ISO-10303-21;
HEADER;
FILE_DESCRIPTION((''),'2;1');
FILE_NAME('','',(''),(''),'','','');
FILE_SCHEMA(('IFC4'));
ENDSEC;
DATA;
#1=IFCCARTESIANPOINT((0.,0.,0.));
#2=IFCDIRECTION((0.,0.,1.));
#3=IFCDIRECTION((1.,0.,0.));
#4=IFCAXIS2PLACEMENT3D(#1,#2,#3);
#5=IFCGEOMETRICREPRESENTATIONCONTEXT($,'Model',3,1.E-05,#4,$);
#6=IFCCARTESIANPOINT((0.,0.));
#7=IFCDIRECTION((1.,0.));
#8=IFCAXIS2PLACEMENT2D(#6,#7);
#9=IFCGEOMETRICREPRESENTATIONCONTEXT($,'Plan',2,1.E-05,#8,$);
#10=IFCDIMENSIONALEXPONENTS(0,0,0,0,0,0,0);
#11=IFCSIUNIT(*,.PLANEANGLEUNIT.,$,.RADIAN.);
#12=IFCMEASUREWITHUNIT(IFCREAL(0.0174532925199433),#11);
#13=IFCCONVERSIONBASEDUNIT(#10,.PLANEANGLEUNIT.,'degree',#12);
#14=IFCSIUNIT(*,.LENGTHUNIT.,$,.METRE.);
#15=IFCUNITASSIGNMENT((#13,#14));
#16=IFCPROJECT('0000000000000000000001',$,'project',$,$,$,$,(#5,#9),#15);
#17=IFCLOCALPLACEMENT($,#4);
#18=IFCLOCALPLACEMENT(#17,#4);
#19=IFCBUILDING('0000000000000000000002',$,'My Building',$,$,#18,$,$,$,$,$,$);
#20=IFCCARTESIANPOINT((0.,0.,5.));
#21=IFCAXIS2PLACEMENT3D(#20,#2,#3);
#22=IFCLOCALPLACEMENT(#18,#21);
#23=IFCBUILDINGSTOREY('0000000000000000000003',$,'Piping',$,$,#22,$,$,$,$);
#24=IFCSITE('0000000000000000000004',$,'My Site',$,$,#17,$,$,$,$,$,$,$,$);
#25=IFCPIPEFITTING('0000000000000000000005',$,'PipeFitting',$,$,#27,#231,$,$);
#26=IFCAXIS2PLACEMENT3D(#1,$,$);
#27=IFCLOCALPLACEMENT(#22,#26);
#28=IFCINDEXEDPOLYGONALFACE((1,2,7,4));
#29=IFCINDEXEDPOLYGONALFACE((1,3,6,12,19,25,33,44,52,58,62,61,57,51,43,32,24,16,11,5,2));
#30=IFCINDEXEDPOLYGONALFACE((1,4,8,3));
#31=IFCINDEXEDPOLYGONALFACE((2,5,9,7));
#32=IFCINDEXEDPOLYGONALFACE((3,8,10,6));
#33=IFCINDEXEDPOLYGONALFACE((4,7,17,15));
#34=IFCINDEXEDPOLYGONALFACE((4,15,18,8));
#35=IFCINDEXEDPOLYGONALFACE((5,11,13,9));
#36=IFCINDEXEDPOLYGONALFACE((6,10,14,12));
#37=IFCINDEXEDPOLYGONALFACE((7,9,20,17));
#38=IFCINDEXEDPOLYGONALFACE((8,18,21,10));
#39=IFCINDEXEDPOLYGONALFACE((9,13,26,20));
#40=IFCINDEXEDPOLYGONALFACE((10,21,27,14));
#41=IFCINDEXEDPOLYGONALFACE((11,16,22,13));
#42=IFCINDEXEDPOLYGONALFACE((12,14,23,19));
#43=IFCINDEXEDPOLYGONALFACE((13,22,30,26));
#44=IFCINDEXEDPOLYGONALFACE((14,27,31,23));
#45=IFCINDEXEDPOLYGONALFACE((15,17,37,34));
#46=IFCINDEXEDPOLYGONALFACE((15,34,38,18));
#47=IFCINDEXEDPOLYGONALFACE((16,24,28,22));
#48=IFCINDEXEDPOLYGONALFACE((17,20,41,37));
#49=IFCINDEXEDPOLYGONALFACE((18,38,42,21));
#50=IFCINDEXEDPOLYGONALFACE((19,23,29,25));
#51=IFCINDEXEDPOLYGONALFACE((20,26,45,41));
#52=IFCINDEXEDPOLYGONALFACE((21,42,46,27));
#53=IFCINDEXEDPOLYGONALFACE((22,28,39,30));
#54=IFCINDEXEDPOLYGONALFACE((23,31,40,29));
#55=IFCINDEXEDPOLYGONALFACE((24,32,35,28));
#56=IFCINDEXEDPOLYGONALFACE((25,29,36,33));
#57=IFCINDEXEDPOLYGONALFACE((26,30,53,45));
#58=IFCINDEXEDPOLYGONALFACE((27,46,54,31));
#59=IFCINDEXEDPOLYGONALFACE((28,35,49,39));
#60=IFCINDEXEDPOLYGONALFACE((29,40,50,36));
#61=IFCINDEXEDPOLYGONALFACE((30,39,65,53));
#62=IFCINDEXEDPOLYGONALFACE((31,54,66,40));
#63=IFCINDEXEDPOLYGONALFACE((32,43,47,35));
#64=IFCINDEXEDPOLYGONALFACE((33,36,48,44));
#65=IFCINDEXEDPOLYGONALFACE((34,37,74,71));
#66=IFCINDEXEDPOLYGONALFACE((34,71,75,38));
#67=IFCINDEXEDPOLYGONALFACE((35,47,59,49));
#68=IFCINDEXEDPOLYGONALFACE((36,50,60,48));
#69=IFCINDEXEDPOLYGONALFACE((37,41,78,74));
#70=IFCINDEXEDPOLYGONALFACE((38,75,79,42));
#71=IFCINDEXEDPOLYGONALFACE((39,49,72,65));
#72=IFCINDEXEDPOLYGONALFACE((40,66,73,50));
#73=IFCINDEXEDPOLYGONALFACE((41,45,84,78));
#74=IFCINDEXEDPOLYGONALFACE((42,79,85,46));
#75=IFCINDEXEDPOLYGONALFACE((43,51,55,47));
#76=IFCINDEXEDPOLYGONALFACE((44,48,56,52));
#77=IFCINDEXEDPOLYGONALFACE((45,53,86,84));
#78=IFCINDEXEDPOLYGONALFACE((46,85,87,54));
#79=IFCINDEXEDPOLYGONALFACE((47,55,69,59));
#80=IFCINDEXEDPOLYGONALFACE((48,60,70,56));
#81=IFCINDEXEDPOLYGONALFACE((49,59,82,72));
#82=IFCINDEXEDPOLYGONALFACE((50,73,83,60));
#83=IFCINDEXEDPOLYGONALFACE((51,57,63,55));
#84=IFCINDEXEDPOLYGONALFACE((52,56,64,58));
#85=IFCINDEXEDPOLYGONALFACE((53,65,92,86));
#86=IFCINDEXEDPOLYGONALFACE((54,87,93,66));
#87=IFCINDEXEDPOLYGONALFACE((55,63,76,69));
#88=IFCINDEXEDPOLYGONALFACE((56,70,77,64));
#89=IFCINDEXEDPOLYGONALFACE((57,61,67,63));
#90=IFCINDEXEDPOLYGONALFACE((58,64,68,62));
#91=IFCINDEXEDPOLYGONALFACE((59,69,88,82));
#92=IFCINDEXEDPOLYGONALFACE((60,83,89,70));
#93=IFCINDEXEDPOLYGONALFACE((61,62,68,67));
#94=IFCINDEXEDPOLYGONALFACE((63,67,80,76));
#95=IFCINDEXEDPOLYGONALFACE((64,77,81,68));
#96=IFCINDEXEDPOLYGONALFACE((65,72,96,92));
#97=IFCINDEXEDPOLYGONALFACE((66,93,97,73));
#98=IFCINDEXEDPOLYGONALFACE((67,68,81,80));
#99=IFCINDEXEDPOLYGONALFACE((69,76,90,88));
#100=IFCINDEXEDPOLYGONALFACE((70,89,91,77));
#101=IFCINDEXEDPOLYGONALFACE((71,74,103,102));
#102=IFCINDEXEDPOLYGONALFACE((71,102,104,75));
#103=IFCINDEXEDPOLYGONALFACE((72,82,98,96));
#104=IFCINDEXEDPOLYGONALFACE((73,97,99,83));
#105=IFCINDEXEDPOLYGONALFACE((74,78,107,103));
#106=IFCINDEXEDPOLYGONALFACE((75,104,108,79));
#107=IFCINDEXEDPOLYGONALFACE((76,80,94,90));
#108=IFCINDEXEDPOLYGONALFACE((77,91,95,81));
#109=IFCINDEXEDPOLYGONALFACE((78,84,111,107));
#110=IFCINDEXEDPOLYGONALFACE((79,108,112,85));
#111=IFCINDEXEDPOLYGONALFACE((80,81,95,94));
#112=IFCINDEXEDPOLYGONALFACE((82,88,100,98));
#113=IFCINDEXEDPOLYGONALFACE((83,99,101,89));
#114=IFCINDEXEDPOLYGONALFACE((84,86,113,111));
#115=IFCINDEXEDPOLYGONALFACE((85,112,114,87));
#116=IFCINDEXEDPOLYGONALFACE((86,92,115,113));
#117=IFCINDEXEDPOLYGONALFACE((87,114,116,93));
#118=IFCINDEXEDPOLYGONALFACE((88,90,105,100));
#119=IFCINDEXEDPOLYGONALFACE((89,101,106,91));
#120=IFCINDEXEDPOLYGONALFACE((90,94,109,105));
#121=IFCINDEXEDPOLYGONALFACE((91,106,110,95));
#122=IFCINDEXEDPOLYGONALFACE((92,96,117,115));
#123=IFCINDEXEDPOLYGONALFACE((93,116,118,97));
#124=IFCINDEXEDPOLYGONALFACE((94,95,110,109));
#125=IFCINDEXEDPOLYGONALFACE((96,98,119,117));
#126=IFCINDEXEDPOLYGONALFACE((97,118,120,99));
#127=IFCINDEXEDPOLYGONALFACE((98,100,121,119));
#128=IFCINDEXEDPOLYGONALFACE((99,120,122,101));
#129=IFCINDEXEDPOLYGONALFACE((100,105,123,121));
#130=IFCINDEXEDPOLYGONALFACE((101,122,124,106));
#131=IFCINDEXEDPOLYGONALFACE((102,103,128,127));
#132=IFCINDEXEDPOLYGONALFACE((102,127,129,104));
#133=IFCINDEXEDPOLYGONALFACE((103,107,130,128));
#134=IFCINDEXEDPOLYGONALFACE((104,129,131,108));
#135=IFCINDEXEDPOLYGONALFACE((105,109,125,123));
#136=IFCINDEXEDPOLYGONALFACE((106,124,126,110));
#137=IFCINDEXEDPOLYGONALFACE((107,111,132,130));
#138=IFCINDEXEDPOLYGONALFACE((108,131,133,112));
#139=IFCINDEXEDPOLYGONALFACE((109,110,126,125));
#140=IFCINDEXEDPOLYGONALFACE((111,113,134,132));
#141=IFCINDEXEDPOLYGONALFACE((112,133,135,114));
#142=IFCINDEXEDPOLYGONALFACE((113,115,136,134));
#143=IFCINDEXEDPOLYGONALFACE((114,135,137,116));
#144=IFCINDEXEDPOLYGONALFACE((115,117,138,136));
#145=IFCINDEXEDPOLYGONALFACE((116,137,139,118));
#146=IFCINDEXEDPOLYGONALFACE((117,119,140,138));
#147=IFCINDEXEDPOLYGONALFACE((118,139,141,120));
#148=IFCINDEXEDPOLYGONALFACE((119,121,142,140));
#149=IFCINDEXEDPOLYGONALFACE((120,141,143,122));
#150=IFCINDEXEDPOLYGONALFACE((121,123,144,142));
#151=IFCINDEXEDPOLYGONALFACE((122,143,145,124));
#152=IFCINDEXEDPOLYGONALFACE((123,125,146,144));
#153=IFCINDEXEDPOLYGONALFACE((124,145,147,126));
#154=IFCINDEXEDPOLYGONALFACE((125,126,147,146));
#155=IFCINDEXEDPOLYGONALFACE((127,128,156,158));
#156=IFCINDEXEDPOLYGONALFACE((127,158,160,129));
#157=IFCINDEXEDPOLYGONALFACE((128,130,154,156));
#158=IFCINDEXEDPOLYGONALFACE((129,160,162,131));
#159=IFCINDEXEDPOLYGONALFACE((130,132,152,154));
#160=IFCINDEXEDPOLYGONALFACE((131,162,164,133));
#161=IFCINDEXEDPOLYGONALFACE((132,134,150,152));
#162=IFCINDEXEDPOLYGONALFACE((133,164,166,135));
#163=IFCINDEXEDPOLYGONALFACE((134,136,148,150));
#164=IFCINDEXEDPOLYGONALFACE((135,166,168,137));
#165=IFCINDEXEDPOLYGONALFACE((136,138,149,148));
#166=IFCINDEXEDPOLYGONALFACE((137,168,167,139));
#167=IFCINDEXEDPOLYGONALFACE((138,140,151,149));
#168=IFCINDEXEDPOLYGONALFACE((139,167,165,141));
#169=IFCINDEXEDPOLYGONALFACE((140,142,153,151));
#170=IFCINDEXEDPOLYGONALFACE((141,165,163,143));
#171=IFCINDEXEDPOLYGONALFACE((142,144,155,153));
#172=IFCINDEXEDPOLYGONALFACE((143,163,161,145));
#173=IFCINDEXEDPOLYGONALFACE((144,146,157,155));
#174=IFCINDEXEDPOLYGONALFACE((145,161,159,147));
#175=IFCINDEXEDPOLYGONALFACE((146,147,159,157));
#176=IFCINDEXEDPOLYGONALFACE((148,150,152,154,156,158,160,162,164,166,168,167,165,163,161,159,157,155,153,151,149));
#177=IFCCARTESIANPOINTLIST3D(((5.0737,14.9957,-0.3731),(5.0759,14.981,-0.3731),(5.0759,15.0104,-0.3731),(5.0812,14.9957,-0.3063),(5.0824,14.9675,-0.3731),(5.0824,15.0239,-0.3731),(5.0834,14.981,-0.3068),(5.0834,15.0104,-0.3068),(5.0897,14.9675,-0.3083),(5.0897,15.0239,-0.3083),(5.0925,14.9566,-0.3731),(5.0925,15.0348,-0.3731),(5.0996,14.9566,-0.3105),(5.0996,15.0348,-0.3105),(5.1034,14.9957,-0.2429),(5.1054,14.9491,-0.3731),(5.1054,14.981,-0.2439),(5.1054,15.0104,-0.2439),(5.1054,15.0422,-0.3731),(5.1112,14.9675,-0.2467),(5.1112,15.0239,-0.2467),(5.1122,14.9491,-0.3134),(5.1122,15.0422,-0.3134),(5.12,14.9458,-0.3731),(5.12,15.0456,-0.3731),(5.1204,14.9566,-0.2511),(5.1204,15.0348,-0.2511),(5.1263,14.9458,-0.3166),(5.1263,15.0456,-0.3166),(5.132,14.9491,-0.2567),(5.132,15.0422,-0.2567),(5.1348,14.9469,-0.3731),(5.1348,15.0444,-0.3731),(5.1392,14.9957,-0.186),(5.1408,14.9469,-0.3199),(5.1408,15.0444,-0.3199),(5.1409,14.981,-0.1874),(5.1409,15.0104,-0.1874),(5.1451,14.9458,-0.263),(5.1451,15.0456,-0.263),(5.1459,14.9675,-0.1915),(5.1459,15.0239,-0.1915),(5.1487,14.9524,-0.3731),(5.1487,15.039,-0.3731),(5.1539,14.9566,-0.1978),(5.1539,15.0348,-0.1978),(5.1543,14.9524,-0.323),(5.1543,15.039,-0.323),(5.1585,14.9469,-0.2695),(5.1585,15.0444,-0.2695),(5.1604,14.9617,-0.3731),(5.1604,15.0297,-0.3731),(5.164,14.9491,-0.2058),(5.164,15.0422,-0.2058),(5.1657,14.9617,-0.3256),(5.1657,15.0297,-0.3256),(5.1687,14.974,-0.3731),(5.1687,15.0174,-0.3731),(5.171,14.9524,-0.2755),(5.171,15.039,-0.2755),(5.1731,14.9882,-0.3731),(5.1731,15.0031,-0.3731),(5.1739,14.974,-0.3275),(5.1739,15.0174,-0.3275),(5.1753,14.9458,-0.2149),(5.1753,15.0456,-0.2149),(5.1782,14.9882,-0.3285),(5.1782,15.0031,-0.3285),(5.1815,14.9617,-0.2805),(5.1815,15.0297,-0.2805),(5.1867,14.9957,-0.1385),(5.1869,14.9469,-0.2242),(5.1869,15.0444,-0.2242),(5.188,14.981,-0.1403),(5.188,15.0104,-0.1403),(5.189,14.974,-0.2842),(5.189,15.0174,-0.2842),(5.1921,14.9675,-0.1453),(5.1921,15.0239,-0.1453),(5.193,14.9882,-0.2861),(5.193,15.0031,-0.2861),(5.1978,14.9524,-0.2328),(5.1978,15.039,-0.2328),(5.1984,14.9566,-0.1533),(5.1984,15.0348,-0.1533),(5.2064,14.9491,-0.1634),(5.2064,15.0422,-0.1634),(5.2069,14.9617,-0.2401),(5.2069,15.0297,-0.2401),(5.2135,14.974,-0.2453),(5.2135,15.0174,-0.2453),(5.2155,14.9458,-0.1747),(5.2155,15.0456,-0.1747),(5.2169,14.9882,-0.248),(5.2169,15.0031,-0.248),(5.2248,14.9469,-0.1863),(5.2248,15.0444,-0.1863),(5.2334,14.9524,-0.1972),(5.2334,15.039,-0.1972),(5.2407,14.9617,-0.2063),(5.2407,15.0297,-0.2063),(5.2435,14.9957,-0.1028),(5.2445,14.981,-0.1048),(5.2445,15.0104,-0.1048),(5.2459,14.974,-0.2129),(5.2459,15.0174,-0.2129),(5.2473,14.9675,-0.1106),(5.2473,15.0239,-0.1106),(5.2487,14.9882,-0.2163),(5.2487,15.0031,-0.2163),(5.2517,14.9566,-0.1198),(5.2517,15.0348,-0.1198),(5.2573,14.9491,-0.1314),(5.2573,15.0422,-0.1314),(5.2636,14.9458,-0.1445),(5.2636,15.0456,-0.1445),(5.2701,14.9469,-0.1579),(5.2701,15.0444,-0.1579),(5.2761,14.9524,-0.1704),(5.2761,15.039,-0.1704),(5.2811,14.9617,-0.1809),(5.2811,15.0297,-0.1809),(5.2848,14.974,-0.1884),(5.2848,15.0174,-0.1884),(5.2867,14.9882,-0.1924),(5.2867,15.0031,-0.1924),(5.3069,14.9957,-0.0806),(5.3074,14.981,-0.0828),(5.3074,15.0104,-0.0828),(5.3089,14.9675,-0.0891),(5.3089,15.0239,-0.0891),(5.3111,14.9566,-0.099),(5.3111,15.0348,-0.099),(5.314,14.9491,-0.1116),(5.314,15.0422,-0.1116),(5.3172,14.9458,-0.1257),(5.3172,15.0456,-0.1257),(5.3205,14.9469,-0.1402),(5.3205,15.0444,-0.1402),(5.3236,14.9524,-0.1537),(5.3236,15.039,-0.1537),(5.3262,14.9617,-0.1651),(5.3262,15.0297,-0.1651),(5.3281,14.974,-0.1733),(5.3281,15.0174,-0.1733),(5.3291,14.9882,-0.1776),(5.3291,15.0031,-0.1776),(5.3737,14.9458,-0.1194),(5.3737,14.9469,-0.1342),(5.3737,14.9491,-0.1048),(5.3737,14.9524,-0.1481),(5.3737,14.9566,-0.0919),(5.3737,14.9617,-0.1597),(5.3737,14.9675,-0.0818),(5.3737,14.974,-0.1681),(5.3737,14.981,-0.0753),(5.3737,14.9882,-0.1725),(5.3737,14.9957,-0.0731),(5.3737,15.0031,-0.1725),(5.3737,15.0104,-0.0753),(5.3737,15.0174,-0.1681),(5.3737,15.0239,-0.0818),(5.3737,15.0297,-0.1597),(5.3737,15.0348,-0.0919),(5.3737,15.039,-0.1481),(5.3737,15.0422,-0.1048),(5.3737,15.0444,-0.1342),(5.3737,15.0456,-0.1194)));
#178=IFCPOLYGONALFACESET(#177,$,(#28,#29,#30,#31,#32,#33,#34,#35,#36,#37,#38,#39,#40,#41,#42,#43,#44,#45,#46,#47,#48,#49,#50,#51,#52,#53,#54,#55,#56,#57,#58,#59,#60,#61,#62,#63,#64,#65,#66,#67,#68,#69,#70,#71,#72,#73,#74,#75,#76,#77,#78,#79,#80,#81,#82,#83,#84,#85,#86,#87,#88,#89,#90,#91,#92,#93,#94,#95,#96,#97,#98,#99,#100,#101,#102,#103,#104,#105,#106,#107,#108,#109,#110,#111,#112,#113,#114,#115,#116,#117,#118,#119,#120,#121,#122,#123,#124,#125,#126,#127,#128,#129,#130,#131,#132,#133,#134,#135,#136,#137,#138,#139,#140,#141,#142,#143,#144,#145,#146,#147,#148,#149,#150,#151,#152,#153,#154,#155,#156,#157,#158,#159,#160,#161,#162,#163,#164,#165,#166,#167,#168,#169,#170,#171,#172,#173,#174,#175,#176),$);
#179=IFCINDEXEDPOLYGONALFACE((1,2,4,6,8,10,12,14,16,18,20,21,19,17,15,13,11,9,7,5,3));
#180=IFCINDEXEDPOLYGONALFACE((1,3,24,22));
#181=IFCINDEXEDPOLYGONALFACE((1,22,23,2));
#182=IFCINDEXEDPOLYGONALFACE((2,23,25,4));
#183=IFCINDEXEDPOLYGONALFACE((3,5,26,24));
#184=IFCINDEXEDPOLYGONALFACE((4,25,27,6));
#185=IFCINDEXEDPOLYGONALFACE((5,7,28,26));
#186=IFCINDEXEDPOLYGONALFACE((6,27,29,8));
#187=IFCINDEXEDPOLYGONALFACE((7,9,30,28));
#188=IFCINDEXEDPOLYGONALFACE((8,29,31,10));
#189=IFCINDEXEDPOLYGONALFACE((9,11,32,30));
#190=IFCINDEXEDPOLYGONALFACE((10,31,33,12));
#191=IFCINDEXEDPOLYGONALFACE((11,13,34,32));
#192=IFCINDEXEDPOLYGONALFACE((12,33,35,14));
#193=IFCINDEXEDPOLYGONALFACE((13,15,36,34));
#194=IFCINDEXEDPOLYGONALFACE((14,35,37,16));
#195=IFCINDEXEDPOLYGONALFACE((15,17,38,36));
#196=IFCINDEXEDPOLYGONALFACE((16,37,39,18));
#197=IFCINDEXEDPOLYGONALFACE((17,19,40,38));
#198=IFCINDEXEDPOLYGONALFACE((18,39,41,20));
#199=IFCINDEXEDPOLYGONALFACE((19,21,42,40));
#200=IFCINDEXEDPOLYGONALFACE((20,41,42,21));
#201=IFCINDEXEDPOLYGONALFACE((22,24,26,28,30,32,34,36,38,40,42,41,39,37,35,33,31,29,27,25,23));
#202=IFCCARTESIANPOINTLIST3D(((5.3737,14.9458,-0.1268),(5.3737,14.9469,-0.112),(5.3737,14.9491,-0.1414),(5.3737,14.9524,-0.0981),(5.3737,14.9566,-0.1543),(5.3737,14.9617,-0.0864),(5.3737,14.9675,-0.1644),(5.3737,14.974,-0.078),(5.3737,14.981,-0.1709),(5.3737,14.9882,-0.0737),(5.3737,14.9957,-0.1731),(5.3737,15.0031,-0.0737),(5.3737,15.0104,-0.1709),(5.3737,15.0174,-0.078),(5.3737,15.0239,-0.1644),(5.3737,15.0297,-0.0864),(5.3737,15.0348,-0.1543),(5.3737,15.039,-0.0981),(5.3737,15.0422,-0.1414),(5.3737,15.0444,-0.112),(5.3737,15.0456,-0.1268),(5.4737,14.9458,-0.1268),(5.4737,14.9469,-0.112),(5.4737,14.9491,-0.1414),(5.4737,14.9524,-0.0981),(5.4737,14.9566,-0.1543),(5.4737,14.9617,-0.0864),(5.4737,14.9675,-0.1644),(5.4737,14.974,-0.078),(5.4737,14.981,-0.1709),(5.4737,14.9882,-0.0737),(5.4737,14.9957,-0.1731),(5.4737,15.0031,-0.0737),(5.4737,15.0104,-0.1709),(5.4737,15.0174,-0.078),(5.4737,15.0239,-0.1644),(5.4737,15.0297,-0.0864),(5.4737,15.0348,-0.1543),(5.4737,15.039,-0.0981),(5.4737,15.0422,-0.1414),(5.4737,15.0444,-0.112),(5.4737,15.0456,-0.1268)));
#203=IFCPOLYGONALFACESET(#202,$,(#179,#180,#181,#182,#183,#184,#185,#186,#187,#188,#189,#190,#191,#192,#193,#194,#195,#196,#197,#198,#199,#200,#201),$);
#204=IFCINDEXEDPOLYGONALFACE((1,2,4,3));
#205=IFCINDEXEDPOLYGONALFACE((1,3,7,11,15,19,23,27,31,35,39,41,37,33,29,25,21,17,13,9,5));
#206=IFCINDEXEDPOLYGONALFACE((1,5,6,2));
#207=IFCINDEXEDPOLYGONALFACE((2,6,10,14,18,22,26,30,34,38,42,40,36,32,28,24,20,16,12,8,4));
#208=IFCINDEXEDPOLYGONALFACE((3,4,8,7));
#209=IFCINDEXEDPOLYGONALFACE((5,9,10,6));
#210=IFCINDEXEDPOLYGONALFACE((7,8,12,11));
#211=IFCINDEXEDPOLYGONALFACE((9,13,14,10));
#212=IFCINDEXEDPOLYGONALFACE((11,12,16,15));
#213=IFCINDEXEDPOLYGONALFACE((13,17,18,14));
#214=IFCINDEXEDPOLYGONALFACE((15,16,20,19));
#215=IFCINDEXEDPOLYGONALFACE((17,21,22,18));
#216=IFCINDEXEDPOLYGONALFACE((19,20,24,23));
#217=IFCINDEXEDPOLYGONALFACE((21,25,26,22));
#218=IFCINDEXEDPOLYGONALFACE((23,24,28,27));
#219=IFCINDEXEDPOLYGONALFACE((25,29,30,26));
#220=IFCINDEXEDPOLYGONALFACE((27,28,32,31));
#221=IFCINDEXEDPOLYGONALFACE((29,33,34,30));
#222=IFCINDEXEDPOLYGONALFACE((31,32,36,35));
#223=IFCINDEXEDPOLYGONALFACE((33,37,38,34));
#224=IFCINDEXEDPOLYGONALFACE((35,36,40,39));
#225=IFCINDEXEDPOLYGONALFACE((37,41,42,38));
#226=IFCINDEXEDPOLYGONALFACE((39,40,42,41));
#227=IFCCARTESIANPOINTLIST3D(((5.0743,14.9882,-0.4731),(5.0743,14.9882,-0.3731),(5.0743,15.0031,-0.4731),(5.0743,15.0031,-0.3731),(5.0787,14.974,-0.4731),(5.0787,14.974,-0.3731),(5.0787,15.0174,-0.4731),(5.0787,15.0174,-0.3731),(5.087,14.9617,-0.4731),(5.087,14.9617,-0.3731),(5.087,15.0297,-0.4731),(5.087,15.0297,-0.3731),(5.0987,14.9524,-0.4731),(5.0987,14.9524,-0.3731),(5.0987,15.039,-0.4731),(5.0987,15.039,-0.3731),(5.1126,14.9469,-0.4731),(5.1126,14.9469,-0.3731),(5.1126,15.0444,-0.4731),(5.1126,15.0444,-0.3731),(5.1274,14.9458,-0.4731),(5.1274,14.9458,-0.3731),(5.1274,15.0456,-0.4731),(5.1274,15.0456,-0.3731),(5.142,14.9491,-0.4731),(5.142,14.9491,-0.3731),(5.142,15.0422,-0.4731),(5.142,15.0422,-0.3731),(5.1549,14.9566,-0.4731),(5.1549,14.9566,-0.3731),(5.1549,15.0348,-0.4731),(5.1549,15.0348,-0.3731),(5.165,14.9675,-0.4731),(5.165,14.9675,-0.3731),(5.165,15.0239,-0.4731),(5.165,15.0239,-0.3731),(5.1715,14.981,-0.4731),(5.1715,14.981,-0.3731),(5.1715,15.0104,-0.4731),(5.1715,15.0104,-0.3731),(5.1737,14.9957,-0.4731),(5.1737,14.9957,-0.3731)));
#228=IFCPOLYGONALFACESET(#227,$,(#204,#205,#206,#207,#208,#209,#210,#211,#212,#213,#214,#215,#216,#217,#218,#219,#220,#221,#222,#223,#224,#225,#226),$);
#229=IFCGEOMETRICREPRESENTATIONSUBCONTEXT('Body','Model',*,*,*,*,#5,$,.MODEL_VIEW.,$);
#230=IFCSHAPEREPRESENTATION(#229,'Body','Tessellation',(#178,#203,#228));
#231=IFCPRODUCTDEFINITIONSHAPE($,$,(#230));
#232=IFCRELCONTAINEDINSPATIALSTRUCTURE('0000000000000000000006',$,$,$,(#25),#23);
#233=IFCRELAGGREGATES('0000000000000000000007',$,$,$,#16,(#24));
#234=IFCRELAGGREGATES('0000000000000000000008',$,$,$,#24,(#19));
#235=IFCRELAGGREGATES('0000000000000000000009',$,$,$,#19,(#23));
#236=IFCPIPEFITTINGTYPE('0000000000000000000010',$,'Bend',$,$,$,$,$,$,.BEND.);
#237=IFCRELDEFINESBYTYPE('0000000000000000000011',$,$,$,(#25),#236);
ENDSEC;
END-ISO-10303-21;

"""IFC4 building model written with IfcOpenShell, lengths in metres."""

from ifc_helpers import new_model, entity, si_unit, converted_unit, frame, origin_with_axes, origin_2d_with_axis, place, context, subcontext, project, spatial, circle, extrude, source, transform, mapped, type_object, type_shapes, element, save


model = new_model("IFC4")

# Units and contexts
model_context = context("Model", 3, precision=1e-05, world=origin_with_axes())
plan_context = context("Plan", 2, precision=1e-05, world=origin_2d_with_axis())
body_context = subcontext(model_context, "Body", "Model", "MODEL_VIEW")
ifc_project = project(units=[converted_unit("PLANEANGLEUNIT", "degree", entity("IfcReal", 0.0174532925199433), si_unit("PLANEANGLEUNIT", "RADIAN"), dimensions=[0, 0, 0, 0, 0, 0, 0]), si_unit("LENGTHUNIT", "METRE")], contexts=[model_context, plan_context])

# Site, building, storey
site_placement = place(None, origin_with_axes())
site = spatial("IfcSite", under=ifc_project, at=site_placement, Name="My Site")
building_placement = place(site_placement, origin_with_axes())
building = spatial("IfcBuilding", under=site, at=building_placement, Name="My Building")
storey_placement = place(building_placement, frame((0.0, 0.0, 5.0), z_axis=(0.0, 0.0, 1.0), x_axis=(1.0, 0.0, 0.0)))
storey = spatial("IfcBuildingStorey", under=building, at=storey_placement, Name="Piping")

# Pipe fitting
pipe_fitting_type_1 = type_object("IfcPipeFittingType", Name="Bend", PredefinedType="BEND")
shared_shape = source(origin_with_axes(), body_context, "Body", "SolidModel", [
    entity("IfcSweptDiskSolid", entity("IfcIndexedPolyCurve", entity("IfcCartesianPointList3D", [[0.0, 0.0, -0.1], [0.0732, 0.0, -0.2768], [0.25, 0.0, -0.35]]), [entity("IfcArcIndex", [1, 2, 3])]), 0.05),
    extrude(circle(Radius=0.05), origin_with_axes(), (0.0, 0.0, -1.0), 0.1),
    extrude(circle(Radius=0.05), frame((0.25, 0.0, -0.35), z_axis=(1.0, 0.0, 0.0), x_axis=(0.0, 0.0, 1.0)), (0.0, 0.0, 1.0), 0.1),
])
type_shapes(pipe_fitting_type_1, [shared_shape])
for number, where, z_axis, x_axis, name in (
    (1, (5.4737, 14.9957, -0.1231), (1.0, 0.000001, 0.0), (0.0, 0.0, -1.0), "PipeFitting"),
):
    element("IfcPipeFitting", number, at=place(storey_placement, frame(where, z_axis=z_axis, x_axis=x_axis)), inside=storey, type_object=pipe_fitting_type_1, Name=name, context=body_context, shape_type="MappedRepresentation", body=[
        mapped(shared_shape, transform((0.0, 0.0, 0.0), x_axis=(1.0, 0.0, 0.0), y_axis=(0.0, 1.0, 0.0), z_axis=(0.0, 0.0, 1.0), scale=1.0)),
    ])

save(model, "model.ifc")
